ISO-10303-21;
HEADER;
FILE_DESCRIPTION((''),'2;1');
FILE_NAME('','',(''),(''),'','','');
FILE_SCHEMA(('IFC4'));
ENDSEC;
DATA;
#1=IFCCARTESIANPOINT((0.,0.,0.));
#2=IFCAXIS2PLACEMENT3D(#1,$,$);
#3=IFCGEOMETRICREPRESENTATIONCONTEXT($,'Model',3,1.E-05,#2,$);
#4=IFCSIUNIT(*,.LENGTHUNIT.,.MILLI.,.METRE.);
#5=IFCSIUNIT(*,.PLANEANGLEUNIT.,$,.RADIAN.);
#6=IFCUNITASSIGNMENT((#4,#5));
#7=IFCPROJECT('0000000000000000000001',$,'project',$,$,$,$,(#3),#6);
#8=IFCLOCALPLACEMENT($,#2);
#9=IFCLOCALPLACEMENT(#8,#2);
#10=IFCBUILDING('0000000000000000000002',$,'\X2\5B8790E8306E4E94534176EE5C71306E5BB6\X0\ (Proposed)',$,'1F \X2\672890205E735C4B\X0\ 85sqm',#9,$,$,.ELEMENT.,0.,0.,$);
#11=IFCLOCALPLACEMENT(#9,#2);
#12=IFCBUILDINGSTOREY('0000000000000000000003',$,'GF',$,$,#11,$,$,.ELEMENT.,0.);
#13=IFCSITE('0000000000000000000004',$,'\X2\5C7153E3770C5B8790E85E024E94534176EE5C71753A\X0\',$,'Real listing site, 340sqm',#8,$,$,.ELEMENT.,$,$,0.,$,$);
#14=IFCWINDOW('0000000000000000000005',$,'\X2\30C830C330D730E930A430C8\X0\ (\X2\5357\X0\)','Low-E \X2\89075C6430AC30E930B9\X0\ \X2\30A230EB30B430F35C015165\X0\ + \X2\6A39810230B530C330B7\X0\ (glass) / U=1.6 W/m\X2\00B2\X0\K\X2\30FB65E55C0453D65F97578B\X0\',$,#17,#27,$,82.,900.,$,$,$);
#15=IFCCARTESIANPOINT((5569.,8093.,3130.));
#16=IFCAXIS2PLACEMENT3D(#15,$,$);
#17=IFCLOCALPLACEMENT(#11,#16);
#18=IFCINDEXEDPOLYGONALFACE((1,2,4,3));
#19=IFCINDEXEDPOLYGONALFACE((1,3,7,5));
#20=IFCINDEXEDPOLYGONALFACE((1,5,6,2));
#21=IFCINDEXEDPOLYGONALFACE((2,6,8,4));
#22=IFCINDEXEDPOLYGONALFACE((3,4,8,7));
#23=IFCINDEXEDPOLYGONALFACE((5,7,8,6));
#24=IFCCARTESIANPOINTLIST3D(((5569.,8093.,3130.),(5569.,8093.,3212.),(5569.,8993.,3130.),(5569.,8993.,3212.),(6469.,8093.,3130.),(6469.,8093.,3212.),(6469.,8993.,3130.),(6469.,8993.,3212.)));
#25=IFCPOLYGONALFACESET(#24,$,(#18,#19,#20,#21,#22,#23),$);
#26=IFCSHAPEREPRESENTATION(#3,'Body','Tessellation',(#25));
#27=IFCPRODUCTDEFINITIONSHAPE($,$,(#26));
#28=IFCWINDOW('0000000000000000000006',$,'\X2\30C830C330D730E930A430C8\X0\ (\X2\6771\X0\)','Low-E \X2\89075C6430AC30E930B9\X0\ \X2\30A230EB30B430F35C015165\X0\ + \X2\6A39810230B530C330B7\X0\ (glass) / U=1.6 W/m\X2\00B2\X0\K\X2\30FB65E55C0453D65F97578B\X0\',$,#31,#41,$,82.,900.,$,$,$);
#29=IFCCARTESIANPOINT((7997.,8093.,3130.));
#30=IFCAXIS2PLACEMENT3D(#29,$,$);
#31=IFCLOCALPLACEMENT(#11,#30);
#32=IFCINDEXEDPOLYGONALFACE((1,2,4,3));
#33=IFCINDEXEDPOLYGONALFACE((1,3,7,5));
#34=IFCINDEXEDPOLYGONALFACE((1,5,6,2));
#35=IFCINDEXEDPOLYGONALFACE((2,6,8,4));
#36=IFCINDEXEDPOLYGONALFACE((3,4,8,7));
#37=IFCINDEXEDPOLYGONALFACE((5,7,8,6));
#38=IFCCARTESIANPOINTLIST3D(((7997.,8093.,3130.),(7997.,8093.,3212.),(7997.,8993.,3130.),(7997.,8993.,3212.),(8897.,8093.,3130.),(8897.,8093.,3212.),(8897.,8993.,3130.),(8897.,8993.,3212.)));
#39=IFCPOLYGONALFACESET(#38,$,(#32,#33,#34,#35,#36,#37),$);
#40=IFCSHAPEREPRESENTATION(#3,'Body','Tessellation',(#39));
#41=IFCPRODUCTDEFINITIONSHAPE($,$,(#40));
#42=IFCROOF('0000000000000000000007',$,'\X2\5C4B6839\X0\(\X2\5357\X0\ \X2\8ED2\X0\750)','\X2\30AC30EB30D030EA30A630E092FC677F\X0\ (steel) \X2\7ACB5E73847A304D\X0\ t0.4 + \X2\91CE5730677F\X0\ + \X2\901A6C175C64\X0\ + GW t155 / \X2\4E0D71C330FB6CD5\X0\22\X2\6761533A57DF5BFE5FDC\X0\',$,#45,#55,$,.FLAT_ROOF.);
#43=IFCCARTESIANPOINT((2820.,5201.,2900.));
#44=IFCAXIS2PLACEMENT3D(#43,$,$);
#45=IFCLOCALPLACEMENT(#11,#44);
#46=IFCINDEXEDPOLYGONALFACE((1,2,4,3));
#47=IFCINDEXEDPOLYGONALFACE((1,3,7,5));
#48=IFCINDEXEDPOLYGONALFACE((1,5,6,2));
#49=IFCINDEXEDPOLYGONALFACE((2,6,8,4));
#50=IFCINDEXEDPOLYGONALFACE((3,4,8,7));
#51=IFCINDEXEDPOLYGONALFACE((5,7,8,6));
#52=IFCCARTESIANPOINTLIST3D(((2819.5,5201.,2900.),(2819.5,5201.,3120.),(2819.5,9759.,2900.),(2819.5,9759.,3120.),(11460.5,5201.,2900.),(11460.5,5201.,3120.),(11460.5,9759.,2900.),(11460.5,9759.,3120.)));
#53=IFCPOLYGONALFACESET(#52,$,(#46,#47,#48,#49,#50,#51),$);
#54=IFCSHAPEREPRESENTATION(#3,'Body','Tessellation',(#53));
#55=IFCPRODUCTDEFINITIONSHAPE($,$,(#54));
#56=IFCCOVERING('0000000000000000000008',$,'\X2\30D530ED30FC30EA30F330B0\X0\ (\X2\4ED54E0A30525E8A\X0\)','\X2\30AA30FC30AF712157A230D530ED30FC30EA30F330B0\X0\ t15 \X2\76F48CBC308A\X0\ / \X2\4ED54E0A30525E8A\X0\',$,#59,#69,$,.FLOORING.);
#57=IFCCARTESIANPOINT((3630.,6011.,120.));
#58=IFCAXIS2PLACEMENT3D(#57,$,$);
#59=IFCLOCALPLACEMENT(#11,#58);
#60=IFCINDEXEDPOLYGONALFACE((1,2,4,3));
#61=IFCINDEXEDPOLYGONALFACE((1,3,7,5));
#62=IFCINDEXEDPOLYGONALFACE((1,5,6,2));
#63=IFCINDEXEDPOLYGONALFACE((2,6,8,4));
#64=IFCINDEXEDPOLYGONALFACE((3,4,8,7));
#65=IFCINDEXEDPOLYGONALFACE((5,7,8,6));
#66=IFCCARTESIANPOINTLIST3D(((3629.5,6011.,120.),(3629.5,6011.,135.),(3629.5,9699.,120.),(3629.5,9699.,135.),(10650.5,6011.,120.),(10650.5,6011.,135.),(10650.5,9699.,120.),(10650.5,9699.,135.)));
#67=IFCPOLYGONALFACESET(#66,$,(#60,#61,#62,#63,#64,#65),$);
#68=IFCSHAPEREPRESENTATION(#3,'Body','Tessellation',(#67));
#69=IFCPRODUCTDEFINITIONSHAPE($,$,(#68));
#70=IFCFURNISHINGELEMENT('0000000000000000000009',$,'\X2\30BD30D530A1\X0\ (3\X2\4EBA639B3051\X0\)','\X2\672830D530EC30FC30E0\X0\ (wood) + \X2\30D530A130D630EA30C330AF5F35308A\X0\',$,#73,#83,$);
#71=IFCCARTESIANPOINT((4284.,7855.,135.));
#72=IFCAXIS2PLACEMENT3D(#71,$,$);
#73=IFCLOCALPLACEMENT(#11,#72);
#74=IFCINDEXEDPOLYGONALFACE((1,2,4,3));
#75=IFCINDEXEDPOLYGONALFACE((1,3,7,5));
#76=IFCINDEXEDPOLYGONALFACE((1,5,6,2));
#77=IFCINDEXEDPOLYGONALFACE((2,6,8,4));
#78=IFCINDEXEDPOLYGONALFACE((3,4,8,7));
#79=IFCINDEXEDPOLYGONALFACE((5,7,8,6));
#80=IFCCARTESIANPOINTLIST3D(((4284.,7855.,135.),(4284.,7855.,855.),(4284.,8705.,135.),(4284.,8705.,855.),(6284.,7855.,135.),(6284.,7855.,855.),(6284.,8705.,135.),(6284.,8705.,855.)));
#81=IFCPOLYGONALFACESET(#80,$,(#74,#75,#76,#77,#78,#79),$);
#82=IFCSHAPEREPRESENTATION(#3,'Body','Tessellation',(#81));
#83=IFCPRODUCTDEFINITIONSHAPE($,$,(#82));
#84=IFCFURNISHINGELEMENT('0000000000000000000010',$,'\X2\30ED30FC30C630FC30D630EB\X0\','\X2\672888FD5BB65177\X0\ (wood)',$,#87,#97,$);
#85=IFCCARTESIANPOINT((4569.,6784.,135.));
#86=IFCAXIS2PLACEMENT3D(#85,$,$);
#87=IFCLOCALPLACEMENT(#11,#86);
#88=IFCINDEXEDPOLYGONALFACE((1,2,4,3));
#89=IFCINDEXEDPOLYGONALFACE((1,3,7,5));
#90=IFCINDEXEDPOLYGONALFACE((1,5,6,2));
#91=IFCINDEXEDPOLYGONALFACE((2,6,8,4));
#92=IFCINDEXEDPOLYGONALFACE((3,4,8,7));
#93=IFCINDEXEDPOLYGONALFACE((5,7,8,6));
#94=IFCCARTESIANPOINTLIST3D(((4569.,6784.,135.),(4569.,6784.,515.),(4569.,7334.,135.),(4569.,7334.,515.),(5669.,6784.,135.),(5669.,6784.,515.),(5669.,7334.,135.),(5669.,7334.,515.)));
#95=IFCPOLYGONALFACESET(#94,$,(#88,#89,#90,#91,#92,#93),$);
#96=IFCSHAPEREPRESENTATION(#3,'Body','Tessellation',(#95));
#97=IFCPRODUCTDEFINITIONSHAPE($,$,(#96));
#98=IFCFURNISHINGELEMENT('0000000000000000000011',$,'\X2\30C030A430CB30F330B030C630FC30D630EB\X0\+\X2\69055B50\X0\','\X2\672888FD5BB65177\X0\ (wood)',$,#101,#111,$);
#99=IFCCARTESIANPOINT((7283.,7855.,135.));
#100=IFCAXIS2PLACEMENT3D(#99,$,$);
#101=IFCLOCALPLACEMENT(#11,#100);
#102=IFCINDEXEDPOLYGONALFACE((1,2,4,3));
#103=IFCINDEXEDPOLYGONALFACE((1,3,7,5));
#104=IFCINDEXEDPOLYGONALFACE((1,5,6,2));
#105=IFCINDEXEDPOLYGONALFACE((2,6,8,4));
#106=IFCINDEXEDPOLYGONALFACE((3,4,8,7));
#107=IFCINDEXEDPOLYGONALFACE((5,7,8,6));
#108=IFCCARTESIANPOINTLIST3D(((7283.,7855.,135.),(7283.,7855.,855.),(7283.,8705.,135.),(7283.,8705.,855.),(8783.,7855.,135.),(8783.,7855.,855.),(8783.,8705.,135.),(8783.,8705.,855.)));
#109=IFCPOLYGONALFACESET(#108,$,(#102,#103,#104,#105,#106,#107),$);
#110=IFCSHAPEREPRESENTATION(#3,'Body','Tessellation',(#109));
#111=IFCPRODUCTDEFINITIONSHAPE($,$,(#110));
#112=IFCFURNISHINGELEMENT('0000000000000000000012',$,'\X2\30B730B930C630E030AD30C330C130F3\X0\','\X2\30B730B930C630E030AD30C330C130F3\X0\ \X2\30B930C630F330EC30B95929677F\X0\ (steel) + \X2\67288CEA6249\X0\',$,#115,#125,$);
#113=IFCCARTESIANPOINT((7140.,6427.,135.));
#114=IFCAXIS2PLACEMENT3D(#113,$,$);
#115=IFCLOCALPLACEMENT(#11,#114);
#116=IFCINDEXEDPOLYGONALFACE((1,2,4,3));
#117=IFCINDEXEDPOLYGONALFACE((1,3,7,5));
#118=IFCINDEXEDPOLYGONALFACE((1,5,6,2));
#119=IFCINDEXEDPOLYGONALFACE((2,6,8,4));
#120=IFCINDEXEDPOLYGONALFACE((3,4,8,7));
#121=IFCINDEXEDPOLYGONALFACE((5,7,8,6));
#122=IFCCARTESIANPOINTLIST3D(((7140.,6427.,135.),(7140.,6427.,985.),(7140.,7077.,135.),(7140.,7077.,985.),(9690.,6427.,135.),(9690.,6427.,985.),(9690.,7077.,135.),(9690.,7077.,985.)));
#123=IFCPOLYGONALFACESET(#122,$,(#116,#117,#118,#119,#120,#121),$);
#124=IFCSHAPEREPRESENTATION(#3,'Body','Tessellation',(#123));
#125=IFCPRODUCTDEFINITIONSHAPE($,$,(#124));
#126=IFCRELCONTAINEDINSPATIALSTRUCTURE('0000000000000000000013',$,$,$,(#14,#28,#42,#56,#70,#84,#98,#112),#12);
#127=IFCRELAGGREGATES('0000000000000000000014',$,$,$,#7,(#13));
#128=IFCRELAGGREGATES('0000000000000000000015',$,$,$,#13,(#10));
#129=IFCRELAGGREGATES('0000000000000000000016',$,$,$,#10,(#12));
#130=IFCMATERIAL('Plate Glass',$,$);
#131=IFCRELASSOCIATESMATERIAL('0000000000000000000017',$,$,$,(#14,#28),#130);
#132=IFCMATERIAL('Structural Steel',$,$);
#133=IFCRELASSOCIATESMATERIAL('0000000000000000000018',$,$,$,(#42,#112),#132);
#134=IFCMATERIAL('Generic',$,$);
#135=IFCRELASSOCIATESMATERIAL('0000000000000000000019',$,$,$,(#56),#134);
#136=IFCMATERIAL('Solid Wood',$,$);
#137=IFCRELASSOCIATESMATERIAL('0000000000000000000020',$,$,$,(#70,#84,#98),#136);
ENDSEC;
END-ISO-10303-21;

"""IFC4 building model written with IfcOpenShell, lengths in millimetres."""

from ifc_helpers import new_model, si_unit, frame, frame_2d, origin, place, context, project, spatial, rectangle, extrude, material, element, save


model = new_model("IFC4")

# Units and contexts
model_context = context("Model", 3, precision=1e-05, world=origin())
ifc_project = project(units=[si_unit("LENGTHUNIT", "METRE", prefix="MILLI"), si_unit("PLANEANGLEUNIT", "RADIAN")], contexts=[model_context])

# Site, building, storey
site_placement = place(None, origin())
site = spatial("IfcSite", under=ifc_project, at=site_placement, Name="山口県宇部市五十目山町", ObjectType="Real listing site, 340sqm", CompositionType="ELEMENT", RefElevation=0.0)
building_placement = place(site_placement, origin())
building = spatial("IfcBuilding", under=site, at=building_placement, Name="宇部の五十目山の家 (Proposed)", ObjectType="1F 木造平屋 85sqm", CompositionType="ELEMENT", ElevationOfRefHeight=0.0, ElevationOfTerrain=0.0)
storey_placement = place(building_placement, origin())
storey = spatial("IfcBuildingStorey", under=building, at=storey_placement, Name="GF", CompositionType="ELEMENT", Elevation=0.0)

# Shared definitions
ifc_material_1 = material(Name="Solid Wood")

# Shared definitions
ifc_material_2 = material(Name="Plate Glass")

# Windows
window_1_placement = place(storey_placement, frame((5569.0, 8093.0, 3130.0)))
element("IfcWindow", 1, at=window_1_placement, inside=storey, material=ifc_material_2, Name="トップライト (南)", Description="Low-E 複層ガラス アルゴン封入 + 樹脂サッシ (glass) / U=1.6 W/m²K・日射取得型", OverallHeight=82.0, OverallWidth=900.0, context=model_context, shape_type="SweptSolid", body=[
    extrude(rectangle(XDim=900.0, YDim=900.0, at=frame_2d((450.0, 450.0))), frame((5569.0, 8093.0, 3130.0)), (0.0, 0.0, 1.0), 82.0),
])
window_2_placement = place(storey_placement, frame((7997.0, 8093.0, 3130.0)))
element("IfcWindow", 2, at=window_2_placement, inside=storey, material=ifc_material_2, Name="トップライト (東)", Description="Low-E 複層ガラス アルゴン封入 + 樹脂サッシ (glass) / U=1.6 W/m²K・日射取得型", OverallHeight=82.0, OverallWidth=900.0, context=model_context, shape_type="SweptSolid", body=[
    extrude(rectangle(XDim=900.0, YDim=900.0, at=frame_2d((450.0, 450.0))), frame((7997.0, 8093.0, 3130.0)), (0.0, 0.0, 1.0), 82.0),
])

# Roof
ifc_material_3 = material(Name="Structural Steel")
roof_placement = place(storey_placement, frame((2820.0, 5201.0, 2900.0)))
element("IfcRoof", 3, at=roof_placement, inside=storey, material=ifc_material_3, Name="屋根(南 軒750)", Description="ガルバリウム鋼板 (steel) 立平葺き t0.4 + 野地板 + 通気層 + GW t155 / 不燃・法22条区域対応", PredefinedType="FLAT_ROOF", context=model_context, shape_type="SweptSolid", body=[
    extrude(rectangle(XDim=8641.0, YDim=4558.0, at=frame_2d((4320.0, 2279.0))), frame((2820.0, 5201.0, 2900.0)), (0.0, 0.0, 1.0), 220.0),
])

# Covering
ifc_material_4 = material(Name="Generic")
covering_placement = place(storey_placement, frame((3630.0, 6011.0, 120.0)))
element("IfcCovering", 4, at=covering_placement, inside=storey, material=ifc_material_4, Name="フローリング (仕上げ床)", Description="オーク無垢フローリング t15 直貼り / 仕上げ床", PredefinedType="FLOORING", context=model_context, shape_type="SweptSolid", body=[
    extrude(rectangle(XDim=7021.0, YDim=3688.0, at=frame_2d((3510.0, 1844.0))), frame((3630.0, 6011.0, 120.0)), (0.0, 0.0, 1.0), 15.0),
])

# Furnishing elements
furnishing_1_placement = place(storey_placement, frame((4284.0, 7855.0, 135.0)))
element("IfcFurnishingElement", 5, at=furnishing_1_placement, inside=storey, material=ifc_material_1, Name="ソファ (3人掛け)", Description="木フレーム (wood) + ファブリック張り", context=model_context, shape_type="SweptSolid", body=[
    extrude(rectangle(XDim=2000.0, YDim=850.0, at=frame_2d((1000.0, 425.0))), frame((4284.0, 7855.0, 135.0)), (0.0, 0.0, 1.0), 720.0),
])
furnishing_2_placement = place(storey_placement, frame((4569.0, 6784.0, 135.0)))
element("IfcFurnishingElement", 6, at=furnishing_2_placement, inside=storey, material=ifc_material_1, Name="ローテーブル", Description="木製家具 (wood)", context=model_context, shape_type="SweptSolid", body=[
    extrude(rectangle(XDim=1100.0, YDim=550.0, at=frame_2d((550.0, 275.0))), frame((4569.0, 6784.0, 135.0)), (0.0, 0.0, 1.0), 380.0),
])
furnishing_3_placement = place(storey_placement, frame((7283.0, 7855.0, 135.0)))
element("IfcFurnishingElement", 7, at=furnishing_3_placement, inside=storey, material=ifc_material_1, Name="ダイニングテーブル+椅子", Description="木製家具 (wood)", context=model_context, shape_type="SweptSolid", body=[
    extrude(rectangle(XDim=1500.0, YDim=850.0, at=frame_2d((750.0, 425.0))), frame((7283.0, 7855.0, 135.0)), (0.0, 0.0, 1.0), 720.0),
])
furnishing_4_placement = place(storey_placement, frame((7140.0, 6427.0, 135.0)))
element("IfcFurnishingElement", 8, at=furnishing_4_placement, inside=storey, material=ifc_material_3, Name="システムキッチン", Description="システムキッチン ステンレス天板 (steel) + 木質扉", context=model_context, shape_type="SweptSolid", body=[
    extrude(rectangle(XDim=2550.0, YDim=650.0, at=frame_2d((1275.0, 325.0))), frame((7140.0, 6427.0, 135.0)), (0.0, 0.0, 1.0), 850.0),
])

save(model, "model.ifc")
